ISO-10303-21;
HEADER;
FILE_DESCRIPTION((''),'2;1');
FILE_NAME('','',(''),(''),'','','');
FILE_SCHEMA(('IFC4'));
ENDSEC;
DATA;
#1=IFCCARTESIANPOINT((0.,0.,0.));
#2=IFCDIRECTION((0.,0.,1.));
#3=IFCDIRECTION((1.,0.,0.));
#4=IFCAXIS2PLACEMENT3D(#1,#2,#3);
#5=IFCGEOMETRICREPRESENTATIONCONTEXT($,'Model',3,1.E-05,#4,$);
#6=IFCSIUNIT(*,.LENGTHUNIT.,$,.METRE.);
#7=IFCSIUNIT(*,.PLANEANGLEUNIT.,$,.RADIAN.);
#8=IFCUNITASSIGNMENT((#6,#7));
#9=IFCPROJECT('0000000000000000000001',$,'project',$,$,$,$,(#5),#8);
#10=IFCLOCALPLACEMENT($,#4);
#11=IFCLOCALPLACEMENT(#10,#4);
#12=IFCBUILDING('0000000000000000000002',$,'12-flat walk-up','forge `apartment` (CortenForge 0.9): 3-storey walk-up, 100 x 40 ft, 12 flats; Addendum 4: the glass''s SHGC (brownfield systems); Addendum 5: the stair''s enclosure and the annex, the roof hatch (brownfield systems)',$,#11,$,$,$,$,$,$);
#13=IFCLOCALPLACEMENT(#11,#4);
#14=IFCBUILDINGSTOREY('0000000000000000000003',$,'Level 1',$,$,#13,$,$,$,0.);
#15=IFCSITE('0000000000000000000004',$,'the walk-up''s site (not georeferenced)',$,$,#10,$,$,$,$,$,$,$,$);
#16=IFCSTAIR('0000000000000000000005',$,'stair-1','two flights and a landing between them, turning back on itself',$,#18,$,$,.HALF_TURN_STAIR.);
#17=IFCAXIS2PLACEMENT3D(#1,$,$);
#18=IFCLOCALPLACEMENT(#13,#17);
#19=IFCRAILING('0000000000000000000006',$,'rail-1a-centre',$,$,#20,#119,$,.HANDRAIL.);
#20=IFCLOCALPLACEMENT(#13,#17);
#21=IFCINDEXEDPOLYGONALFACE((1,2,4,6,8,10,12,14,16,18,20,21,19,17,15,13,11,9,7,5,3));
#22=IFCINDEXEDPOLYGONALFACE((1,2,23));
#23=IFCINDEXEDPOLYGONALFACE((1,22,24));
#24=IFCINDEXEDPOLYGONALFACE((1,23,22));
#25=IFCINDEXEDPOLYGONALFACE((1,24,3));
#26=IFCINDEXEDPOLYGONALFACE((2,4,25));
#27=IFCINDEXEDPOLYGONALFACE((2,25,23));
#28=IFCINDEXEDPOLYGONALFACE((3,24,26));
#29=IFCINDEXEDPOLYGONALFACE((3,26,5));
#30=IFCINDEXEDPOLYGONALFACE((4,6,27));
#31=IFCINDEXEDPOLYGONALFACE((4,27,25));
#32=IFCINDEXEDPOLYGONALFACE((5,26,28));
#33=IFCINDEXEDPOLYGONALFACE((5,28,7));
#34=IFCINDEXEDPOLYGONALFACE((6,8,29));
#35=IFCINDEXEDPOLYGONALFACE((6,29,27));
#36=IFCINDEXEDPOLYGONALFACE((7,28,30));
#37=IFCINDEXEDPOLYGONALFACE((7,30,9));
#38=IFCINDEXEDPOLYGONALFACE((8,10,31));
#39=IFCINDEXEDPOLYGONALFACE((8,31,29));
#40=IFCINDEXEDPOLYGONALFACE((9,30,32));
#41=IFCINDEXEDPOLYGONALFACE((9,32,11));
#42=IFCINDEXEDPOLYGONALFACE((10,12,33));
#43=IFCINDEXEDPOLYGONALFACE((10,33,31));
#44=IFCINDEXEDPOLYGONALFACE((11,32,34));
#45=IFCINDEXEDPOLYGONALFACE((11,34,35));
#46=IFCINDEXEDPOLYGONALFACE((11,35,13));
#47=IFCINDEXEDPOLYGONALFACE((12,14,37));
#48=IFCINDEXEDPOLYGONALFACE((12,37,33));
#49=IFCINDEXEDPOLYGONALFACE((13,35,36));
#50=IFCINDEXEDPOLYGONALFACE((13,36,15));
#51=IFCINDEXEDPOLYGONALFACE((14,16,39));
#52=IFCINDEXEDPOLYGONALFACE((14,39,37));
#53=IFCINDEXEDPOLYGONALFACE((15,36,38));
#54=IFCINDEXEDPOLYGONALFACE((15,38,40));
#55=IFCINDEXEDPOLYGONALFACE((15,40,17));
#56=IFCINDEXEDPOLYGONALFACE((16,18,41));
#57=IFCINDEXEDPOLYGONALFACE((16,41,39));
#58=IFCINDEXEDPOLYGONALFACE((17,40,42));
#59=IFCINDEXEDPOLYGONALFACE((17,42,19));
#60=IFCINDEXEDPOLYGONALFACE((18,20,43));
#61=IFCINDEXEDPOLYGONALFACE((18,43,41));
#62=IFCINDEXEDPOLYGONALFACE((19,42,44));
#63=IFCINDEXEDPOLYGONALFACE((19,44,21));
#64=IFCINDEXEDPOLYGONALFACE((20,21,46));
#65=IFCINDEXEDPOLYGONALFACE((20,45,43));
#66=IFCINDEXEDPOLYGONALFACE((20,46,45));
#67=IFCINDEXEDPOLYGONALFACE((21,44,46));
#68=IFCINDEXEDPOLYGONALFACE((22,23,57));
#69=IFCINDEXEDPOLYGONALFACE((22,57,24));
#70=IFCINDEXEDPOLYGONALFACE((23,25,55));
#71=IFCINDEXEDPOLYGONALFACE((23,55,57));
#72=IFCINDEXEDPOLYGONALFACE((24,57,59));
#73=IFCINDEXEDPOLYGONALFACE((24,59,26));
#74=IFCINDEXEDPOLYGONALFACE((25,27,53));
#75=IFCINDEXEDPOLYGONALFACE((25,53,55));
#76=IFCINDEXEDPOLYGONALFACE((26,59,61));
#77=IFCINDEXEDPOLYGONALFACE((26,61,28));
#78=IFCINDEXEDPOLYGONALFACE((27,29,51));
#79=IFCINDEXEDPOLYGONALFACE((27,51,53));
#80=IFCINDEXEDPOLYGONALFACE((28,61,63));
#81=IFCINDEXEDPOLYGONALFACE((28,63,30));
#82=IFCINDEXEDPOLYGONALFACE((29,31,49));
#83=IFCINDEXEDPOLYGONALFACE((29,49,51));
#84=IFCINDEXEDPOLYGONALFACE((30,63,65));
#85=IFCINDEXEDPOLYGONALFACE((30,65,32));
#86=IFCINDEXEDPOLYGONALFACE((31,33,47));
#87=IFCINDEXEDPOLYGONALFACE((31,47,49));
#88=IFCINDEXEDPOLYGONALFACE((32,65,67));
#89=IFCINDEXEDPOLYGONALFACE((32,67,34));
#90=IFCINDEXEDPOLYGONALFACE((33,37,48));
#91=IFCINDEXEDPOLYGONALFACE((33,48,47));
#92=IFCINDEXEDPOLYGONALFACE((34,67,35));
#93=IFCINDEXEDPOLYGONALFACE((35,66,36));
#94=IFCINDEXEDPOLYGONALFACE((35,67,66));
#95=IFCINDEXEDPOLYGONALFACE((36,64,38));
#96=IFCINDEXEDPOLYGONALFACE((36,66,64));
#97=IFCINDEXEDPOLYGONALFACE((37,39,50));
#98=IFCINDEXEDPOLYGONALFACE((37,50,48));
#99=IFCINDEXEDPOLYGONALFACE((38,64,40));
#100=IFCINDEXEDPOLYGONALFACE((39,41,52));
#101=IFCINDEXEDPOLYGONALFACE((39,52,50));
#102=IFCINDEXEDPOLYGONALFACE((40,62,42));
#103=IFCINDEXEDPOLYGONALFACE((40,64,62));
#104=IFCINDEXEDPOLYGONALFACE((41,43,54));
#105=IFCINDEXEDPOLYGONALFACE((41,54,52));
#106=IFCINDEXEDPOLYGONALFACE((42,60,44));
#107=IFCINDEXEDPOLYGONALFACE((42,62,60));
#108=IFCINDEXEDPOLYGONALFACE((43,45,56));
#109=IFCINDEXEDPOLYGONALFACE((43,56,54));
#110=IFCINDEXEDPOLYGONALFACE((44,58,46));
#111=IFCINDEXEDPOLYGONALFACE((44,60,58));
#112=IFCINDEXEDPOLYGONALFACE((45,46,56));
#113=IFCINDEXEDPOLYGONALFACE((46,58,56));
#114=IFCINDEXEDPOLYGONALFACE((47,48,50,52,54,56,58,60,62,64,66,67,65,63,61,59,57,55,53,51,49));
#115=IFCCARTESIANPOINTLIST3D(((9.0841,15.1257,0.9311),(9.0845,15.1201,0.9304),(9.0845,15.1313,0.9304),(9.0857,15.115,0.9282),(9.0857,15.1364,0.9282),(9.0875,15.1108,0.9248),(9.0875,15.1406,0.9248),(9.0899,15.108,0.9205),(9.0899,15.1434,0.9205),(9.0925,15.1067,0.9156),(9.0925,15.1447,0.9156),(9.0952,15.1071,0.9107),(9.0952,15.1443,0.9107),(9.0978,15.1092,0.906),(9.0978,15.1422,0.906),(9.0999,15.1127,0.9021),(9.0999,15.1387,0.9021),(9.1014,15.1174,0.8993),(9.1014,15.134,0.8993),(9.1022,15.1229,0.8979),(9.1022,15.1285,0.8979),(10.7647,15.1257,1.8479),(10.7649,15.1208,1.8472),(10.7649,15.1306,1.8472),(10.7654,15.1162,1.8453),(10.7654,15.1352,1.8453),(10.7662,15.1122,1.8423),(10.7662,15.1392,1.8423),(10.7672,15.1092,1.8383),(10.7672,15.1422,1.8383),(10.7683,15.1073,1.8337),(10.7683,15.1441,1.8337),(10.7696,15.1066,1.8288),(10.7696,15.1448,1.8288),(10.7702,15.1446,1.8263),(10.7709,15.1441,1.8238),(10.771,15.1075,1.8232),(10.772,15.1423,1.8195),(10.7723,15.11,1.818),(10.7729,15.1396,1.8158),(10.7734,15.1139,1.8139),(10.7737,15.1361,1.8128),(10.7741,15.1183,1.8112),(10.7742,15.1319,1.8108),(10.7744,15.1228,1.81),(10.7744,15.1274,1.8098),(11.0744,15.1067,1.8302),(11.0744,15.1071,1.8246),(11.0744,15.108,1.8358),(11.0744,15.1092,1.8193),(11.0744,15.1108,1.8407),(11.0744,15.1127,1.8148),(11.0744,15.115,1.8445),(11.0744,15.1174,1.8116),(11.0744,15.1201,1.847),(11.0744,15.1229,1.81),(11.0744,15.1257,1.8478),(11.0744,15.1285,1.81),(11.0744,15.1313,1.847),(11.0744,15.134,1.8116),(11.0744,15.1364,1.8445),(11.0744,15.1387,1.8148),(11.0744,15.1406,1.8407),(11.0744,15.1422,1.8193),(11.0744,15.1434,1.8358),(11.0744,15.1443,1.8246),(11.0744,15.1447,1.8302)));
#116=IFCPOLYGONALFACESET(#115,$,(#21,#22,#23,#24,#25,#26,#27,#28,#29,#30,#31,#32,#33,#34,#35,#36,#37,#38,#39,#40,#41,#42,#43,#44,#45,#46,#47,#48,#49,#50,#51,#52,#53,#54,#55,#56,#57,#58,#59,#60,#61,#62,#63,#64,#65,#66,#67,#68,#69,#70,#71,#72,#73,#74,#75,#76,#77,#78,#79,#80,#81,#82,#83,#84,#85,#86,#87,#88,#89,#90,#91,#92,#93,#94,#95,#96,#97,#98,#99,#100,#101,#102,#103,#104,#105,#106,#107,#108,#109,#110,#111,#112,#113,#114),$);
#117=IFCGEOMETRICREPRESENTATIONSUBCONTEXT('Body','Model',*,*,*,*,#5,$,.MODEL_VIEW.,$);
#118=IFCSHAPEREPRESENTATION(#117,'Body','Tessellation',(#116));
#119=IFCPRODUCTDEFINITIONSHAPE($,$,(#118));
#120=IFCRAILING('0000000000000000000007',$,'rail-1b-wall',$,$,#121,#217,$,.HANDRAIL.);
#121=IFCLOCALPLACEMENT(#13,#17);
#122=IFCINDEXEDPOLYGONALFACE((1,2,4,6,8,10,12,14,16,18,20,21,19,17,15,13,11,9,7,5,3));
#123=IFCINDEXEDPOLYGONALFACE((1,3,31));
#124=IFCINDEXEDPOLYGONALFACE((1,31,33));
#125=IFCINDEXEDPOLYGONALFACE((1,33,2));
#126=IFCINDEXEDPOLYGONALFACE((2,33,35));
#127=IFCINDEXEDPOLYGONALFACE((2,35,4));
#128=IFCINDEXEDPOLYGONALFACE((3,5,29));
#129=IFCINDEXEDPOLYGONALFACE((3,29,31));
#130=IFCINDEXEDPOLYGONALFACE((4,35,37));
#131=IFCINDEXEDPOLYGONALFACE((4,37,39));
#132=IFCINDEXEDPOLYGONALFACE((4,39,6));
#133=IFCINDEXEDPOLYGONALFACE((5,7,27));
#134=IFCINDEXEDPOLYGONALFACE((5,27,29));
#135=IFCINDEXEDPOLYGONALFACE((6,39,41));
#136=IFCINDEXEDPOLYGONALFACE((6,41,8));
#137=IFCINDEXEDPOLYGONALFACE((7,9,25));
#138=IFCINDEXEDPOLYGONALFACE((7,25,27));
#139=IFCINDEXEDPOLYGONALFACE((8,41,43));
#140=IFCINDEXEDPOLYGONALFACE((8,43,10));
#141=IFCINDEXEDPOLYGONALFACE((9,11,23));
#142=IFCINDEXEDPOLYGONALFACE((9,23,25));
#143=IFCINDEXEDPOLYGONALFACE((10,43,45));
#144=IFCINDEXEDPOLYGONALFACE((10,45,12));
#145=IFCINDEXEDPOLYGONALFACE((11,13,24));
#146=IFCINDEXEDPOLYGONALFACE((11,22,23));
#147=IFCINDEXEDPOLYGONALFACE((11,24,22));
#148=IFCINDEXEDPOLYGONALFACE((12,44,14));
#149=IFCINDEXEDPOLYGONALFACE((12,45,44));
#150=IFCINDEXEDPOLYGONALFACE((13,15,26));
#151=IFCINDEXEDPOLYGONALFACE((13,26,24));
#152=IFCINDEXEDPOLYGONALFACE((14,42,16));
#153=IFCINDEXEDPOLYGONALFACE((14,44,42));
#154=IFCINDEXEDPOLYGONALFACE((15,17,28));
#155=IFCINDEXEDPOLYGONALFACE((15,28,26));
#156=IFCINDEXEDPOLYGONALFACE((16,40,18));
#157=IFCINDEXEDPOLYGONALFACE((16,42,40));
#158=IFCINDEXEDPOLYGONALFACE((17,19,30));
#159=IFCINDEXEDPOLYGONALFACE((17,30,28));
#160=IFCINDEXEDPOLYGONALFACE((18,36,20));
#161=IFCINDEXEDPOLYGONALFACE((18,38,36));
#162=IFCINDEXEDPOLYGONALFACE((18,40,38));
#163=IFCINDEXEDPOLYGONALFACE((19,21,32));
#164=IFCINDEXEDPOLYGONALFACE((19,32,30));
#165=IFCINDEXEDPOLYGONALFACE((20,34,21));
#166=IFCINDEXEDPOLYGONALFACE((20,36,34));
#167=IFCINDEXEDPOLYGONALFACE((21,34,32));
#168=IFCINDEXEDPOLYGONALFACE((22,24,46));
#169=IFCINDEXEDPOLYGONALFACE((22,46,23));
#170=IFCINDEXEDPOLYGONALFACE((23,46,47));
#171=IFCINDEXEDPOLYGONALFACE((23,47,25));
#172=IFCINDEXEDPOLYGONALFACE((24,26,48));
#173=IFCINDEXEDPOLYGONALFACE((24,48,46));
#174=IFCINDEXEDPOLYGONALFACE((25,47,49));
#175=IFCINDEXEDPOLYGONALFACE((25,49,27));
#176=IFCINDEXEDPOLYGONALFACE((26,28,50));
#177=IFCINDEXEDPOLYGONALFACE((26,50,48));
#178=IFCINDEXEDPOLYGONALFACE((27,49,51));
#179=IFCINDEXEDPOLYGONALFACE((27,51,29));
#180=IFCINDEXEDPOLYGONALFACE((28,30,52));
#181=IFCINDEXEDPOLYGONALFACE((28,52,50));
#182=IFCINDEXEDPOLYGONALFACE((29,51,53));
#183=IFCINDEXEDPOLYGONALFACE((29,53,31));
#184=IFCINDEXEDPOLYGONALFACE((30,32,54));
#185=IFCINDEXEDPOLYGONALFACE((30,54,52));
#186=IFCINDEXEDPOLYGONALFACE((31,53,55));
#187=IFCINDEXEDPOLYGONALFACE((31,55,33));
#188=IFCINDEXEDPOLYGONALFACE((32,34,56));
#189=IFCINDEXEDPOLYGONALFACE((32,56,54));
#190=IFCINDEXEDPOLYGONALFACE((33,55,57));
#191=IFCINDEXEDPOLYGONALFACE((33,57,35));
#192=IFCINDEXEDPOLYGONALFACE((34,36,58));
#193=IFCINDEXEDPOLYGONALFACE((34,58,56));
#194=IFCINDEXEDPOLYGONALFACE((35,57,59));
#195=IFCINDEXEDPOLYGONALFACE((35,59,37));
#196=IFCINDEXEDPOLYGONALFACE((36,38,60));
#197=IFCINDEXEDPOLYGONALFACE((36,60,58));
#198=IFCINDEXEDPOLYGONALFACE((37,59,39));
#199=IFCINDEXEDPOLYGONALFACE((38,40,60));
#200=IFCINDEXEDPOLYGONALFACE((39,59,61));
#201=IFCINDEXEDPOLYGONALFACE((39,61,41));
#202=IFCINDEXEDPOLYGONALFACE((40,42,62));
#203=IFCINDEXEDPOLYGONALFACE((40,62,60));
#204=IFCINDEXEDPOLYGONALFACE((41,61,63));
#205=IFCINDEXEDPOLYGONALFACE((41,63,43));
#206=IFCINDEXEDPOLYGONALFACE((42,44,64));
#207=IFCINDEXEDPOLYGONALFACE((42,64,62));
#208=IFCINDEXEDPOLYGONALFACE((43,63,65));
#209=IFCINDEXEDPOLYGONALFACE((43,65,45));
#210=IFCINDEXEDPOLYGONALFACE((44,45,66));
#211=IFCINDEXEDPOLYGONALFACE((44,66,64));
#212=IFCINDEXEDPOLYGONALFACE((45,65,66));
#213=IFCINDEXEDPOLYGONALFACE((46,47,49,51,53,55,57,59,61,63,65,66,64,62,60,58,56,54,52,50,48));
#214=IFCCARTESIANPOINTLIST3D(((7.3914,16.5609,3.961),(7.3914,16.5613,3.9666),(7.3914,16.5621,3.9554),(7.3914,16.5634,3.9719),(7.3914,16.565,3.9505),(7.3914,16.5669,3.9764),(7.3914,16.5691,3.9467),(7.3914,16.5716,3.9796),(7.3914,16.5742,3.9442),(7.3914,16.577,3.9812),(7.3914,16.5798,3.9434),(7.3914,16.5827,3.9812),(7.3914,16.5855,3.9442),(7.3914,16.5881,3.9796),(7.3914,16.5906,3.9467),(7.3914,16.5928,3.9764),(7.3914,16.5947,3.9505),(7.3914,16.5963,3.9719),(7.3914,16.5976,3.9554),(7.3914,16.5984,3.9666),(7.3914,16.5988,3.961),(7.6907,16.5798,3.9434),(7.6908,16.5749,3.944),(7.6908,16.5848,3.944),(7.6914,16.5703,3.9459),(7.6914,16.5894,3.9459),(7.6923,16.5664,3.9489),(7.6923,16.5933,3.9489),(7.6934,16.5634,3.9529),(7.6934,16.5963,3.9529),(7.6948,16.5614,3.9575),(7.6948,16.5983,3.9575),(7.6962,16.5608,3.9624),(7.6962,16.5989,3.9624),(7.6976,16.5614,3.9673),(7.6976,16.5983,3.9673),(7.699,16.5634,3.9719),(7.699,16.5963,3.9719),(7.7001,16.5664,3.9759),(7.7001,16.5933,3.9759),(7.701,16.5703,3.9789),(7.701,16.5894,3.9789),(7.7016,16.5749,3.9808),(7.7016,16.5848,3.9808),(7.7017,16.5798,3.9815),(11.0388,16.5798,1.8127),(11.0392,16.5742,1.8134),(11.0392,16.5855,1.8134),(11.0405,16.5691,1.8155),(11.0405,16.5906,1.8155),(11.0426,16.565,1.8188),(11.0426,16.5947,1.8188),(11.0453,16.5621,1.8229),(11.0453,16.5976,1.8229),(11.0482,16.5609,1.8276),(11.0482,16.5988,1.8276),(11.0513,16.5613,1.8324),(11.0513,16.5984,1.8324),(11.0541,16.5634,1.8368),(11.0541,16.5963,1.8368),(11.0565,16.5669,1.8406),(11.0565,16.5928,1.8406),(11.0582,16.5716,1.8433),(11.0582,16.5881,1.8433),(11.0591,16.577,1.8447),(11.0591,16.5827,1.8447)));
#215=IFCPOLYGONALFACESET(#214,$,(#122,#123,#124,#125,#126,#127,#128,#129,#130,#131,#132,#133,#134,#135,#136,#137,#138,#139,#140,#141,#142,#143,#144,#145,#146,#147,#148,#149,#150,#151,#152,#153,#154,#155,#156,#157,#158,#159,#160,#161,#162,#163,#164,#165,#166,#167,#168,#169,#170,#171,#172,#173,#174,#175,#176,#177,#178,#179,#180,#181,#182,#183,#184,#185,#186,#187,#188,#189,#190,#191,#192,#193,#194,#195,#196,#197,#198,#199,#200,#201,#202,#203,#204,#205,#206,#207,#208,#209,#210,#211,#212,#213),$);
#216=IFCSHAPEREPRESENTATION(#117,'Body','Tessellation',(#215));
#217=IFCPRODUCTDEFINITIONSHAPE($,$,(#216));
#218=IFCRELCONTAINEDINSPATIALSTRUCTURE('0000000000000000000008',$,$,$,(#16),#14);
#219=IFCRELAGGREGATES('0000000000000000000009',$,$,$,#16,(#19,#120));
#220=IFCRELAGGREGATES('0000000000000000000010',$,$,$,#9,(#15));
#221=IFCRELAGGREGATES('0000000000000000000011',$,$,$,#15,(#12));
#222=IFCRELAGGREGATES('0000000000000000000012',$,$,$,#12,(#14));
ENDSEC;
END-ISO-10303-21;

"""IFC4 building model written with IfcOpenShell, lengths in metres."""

from ifc_helpers import new_model, entity, si_unit, frame, origin_with_axes, place, context, subcontext, project, spatial, element, aggregate, save


model = new_model("IFC4")

# Units and contexts
model_context = context("Model", 3, precision=1e-05, world=origin_with_axes())
body_context = subcontext(model_context, "Body", "Model", "MODEL_VIEW")
ifc_project = project(units=[si_unit("LENGTHUNIT", "METRE"), si_unit("PLANEANGLEUNIT", "RADIAN")], contexts=[model_context])

# Site, building, storey
site_placement = place(None, origin_with_axes())
site = spatial("IfcSite", under=ifc_project, at=site_placement, Name="the walk-up's site (not georeferenced)")
building_placement = place(site_placement, origin_with_axes())
building = spatial("IfcBuilding", under=site, at=building_placement, Name="12-flat walk-up", Description="forge `apartment` (CortenForge 0.9): 3-storey walk-up, 100 x 40 ft, 12 flats; Addendum 4: the glass's SHGC (brownfield systems); Addendum 5: the stair's enclosure and the annex, the roof hatch (brownfield systems)")
storey_placement = place(building_placement, origin_with_axes())
storey = spatial("IfcBuildingStorey", under=building, at=storey_placement, Name="Level 1", Elevation=0.0)

# Stair, railings
stair_placement = place(storey_placement, origin_with_axes())
stair = element("IfcStair", 1, at=stair_placement, inside=storey, Name="stair-1", Description="two flights and a landing between them, turning back on itself", PredefinedType="HALF_TURN_STAIR")
railing_1_placement = place(stair_placement, frame((9.0932, 15.1257, 0.9144), z_axis=(0.0, 0.0, 1.0), x_axis=(1.0, 0.0, 0.0)))
railing_1 = element("IfcRailing", 2, at=railing_1_placement, Name="rail-1a-centre", PredefinedType="HANDRAIL", context=body_context, shape_type="AdvancedSweptSolid", body=[
    entity("IfcSweptDiskSolid", entity("IfcPolyline", [entity("IfcCartesianPoint", [0.0, 0.0, 0.0]), entity("IfcCartesianPoint", [1.6764, 0.0, 0.9144]), entity("IfcCartesianPoint", [1.9812, 0.0, 0.9144])]), 0.0191),
])
railing_2_placement = place(stair_placement, frame((11.049, 16.5799, 1.8288), z_axis=(0.0, 0.0, 1.0), x_axis=(1.0, 0.0, 0.0)))
railing_2 = element("IfcRailing", 3, at=railing_2_placement, Name="rail-1b-wall", PredefinedType="HANDRAIL", context=body_context, shape_type="AdvancedSweptSolid", body=[
    entity("IfcSweptDiskSolid", entity("IfcPolyline", [entity("IfcCartesianPoint", [0.0, 0.0, 0.0]), entity("IfcCartesianPoint", [-3.3528, 0.0, 2.1336]), entity("IfcCartesianPoint", [-3.6576, 0.0, 2.1336])]), 0.0191),
])
aggregate(stair, [railing_1, railing_2])

save(model, "model.ifc")
